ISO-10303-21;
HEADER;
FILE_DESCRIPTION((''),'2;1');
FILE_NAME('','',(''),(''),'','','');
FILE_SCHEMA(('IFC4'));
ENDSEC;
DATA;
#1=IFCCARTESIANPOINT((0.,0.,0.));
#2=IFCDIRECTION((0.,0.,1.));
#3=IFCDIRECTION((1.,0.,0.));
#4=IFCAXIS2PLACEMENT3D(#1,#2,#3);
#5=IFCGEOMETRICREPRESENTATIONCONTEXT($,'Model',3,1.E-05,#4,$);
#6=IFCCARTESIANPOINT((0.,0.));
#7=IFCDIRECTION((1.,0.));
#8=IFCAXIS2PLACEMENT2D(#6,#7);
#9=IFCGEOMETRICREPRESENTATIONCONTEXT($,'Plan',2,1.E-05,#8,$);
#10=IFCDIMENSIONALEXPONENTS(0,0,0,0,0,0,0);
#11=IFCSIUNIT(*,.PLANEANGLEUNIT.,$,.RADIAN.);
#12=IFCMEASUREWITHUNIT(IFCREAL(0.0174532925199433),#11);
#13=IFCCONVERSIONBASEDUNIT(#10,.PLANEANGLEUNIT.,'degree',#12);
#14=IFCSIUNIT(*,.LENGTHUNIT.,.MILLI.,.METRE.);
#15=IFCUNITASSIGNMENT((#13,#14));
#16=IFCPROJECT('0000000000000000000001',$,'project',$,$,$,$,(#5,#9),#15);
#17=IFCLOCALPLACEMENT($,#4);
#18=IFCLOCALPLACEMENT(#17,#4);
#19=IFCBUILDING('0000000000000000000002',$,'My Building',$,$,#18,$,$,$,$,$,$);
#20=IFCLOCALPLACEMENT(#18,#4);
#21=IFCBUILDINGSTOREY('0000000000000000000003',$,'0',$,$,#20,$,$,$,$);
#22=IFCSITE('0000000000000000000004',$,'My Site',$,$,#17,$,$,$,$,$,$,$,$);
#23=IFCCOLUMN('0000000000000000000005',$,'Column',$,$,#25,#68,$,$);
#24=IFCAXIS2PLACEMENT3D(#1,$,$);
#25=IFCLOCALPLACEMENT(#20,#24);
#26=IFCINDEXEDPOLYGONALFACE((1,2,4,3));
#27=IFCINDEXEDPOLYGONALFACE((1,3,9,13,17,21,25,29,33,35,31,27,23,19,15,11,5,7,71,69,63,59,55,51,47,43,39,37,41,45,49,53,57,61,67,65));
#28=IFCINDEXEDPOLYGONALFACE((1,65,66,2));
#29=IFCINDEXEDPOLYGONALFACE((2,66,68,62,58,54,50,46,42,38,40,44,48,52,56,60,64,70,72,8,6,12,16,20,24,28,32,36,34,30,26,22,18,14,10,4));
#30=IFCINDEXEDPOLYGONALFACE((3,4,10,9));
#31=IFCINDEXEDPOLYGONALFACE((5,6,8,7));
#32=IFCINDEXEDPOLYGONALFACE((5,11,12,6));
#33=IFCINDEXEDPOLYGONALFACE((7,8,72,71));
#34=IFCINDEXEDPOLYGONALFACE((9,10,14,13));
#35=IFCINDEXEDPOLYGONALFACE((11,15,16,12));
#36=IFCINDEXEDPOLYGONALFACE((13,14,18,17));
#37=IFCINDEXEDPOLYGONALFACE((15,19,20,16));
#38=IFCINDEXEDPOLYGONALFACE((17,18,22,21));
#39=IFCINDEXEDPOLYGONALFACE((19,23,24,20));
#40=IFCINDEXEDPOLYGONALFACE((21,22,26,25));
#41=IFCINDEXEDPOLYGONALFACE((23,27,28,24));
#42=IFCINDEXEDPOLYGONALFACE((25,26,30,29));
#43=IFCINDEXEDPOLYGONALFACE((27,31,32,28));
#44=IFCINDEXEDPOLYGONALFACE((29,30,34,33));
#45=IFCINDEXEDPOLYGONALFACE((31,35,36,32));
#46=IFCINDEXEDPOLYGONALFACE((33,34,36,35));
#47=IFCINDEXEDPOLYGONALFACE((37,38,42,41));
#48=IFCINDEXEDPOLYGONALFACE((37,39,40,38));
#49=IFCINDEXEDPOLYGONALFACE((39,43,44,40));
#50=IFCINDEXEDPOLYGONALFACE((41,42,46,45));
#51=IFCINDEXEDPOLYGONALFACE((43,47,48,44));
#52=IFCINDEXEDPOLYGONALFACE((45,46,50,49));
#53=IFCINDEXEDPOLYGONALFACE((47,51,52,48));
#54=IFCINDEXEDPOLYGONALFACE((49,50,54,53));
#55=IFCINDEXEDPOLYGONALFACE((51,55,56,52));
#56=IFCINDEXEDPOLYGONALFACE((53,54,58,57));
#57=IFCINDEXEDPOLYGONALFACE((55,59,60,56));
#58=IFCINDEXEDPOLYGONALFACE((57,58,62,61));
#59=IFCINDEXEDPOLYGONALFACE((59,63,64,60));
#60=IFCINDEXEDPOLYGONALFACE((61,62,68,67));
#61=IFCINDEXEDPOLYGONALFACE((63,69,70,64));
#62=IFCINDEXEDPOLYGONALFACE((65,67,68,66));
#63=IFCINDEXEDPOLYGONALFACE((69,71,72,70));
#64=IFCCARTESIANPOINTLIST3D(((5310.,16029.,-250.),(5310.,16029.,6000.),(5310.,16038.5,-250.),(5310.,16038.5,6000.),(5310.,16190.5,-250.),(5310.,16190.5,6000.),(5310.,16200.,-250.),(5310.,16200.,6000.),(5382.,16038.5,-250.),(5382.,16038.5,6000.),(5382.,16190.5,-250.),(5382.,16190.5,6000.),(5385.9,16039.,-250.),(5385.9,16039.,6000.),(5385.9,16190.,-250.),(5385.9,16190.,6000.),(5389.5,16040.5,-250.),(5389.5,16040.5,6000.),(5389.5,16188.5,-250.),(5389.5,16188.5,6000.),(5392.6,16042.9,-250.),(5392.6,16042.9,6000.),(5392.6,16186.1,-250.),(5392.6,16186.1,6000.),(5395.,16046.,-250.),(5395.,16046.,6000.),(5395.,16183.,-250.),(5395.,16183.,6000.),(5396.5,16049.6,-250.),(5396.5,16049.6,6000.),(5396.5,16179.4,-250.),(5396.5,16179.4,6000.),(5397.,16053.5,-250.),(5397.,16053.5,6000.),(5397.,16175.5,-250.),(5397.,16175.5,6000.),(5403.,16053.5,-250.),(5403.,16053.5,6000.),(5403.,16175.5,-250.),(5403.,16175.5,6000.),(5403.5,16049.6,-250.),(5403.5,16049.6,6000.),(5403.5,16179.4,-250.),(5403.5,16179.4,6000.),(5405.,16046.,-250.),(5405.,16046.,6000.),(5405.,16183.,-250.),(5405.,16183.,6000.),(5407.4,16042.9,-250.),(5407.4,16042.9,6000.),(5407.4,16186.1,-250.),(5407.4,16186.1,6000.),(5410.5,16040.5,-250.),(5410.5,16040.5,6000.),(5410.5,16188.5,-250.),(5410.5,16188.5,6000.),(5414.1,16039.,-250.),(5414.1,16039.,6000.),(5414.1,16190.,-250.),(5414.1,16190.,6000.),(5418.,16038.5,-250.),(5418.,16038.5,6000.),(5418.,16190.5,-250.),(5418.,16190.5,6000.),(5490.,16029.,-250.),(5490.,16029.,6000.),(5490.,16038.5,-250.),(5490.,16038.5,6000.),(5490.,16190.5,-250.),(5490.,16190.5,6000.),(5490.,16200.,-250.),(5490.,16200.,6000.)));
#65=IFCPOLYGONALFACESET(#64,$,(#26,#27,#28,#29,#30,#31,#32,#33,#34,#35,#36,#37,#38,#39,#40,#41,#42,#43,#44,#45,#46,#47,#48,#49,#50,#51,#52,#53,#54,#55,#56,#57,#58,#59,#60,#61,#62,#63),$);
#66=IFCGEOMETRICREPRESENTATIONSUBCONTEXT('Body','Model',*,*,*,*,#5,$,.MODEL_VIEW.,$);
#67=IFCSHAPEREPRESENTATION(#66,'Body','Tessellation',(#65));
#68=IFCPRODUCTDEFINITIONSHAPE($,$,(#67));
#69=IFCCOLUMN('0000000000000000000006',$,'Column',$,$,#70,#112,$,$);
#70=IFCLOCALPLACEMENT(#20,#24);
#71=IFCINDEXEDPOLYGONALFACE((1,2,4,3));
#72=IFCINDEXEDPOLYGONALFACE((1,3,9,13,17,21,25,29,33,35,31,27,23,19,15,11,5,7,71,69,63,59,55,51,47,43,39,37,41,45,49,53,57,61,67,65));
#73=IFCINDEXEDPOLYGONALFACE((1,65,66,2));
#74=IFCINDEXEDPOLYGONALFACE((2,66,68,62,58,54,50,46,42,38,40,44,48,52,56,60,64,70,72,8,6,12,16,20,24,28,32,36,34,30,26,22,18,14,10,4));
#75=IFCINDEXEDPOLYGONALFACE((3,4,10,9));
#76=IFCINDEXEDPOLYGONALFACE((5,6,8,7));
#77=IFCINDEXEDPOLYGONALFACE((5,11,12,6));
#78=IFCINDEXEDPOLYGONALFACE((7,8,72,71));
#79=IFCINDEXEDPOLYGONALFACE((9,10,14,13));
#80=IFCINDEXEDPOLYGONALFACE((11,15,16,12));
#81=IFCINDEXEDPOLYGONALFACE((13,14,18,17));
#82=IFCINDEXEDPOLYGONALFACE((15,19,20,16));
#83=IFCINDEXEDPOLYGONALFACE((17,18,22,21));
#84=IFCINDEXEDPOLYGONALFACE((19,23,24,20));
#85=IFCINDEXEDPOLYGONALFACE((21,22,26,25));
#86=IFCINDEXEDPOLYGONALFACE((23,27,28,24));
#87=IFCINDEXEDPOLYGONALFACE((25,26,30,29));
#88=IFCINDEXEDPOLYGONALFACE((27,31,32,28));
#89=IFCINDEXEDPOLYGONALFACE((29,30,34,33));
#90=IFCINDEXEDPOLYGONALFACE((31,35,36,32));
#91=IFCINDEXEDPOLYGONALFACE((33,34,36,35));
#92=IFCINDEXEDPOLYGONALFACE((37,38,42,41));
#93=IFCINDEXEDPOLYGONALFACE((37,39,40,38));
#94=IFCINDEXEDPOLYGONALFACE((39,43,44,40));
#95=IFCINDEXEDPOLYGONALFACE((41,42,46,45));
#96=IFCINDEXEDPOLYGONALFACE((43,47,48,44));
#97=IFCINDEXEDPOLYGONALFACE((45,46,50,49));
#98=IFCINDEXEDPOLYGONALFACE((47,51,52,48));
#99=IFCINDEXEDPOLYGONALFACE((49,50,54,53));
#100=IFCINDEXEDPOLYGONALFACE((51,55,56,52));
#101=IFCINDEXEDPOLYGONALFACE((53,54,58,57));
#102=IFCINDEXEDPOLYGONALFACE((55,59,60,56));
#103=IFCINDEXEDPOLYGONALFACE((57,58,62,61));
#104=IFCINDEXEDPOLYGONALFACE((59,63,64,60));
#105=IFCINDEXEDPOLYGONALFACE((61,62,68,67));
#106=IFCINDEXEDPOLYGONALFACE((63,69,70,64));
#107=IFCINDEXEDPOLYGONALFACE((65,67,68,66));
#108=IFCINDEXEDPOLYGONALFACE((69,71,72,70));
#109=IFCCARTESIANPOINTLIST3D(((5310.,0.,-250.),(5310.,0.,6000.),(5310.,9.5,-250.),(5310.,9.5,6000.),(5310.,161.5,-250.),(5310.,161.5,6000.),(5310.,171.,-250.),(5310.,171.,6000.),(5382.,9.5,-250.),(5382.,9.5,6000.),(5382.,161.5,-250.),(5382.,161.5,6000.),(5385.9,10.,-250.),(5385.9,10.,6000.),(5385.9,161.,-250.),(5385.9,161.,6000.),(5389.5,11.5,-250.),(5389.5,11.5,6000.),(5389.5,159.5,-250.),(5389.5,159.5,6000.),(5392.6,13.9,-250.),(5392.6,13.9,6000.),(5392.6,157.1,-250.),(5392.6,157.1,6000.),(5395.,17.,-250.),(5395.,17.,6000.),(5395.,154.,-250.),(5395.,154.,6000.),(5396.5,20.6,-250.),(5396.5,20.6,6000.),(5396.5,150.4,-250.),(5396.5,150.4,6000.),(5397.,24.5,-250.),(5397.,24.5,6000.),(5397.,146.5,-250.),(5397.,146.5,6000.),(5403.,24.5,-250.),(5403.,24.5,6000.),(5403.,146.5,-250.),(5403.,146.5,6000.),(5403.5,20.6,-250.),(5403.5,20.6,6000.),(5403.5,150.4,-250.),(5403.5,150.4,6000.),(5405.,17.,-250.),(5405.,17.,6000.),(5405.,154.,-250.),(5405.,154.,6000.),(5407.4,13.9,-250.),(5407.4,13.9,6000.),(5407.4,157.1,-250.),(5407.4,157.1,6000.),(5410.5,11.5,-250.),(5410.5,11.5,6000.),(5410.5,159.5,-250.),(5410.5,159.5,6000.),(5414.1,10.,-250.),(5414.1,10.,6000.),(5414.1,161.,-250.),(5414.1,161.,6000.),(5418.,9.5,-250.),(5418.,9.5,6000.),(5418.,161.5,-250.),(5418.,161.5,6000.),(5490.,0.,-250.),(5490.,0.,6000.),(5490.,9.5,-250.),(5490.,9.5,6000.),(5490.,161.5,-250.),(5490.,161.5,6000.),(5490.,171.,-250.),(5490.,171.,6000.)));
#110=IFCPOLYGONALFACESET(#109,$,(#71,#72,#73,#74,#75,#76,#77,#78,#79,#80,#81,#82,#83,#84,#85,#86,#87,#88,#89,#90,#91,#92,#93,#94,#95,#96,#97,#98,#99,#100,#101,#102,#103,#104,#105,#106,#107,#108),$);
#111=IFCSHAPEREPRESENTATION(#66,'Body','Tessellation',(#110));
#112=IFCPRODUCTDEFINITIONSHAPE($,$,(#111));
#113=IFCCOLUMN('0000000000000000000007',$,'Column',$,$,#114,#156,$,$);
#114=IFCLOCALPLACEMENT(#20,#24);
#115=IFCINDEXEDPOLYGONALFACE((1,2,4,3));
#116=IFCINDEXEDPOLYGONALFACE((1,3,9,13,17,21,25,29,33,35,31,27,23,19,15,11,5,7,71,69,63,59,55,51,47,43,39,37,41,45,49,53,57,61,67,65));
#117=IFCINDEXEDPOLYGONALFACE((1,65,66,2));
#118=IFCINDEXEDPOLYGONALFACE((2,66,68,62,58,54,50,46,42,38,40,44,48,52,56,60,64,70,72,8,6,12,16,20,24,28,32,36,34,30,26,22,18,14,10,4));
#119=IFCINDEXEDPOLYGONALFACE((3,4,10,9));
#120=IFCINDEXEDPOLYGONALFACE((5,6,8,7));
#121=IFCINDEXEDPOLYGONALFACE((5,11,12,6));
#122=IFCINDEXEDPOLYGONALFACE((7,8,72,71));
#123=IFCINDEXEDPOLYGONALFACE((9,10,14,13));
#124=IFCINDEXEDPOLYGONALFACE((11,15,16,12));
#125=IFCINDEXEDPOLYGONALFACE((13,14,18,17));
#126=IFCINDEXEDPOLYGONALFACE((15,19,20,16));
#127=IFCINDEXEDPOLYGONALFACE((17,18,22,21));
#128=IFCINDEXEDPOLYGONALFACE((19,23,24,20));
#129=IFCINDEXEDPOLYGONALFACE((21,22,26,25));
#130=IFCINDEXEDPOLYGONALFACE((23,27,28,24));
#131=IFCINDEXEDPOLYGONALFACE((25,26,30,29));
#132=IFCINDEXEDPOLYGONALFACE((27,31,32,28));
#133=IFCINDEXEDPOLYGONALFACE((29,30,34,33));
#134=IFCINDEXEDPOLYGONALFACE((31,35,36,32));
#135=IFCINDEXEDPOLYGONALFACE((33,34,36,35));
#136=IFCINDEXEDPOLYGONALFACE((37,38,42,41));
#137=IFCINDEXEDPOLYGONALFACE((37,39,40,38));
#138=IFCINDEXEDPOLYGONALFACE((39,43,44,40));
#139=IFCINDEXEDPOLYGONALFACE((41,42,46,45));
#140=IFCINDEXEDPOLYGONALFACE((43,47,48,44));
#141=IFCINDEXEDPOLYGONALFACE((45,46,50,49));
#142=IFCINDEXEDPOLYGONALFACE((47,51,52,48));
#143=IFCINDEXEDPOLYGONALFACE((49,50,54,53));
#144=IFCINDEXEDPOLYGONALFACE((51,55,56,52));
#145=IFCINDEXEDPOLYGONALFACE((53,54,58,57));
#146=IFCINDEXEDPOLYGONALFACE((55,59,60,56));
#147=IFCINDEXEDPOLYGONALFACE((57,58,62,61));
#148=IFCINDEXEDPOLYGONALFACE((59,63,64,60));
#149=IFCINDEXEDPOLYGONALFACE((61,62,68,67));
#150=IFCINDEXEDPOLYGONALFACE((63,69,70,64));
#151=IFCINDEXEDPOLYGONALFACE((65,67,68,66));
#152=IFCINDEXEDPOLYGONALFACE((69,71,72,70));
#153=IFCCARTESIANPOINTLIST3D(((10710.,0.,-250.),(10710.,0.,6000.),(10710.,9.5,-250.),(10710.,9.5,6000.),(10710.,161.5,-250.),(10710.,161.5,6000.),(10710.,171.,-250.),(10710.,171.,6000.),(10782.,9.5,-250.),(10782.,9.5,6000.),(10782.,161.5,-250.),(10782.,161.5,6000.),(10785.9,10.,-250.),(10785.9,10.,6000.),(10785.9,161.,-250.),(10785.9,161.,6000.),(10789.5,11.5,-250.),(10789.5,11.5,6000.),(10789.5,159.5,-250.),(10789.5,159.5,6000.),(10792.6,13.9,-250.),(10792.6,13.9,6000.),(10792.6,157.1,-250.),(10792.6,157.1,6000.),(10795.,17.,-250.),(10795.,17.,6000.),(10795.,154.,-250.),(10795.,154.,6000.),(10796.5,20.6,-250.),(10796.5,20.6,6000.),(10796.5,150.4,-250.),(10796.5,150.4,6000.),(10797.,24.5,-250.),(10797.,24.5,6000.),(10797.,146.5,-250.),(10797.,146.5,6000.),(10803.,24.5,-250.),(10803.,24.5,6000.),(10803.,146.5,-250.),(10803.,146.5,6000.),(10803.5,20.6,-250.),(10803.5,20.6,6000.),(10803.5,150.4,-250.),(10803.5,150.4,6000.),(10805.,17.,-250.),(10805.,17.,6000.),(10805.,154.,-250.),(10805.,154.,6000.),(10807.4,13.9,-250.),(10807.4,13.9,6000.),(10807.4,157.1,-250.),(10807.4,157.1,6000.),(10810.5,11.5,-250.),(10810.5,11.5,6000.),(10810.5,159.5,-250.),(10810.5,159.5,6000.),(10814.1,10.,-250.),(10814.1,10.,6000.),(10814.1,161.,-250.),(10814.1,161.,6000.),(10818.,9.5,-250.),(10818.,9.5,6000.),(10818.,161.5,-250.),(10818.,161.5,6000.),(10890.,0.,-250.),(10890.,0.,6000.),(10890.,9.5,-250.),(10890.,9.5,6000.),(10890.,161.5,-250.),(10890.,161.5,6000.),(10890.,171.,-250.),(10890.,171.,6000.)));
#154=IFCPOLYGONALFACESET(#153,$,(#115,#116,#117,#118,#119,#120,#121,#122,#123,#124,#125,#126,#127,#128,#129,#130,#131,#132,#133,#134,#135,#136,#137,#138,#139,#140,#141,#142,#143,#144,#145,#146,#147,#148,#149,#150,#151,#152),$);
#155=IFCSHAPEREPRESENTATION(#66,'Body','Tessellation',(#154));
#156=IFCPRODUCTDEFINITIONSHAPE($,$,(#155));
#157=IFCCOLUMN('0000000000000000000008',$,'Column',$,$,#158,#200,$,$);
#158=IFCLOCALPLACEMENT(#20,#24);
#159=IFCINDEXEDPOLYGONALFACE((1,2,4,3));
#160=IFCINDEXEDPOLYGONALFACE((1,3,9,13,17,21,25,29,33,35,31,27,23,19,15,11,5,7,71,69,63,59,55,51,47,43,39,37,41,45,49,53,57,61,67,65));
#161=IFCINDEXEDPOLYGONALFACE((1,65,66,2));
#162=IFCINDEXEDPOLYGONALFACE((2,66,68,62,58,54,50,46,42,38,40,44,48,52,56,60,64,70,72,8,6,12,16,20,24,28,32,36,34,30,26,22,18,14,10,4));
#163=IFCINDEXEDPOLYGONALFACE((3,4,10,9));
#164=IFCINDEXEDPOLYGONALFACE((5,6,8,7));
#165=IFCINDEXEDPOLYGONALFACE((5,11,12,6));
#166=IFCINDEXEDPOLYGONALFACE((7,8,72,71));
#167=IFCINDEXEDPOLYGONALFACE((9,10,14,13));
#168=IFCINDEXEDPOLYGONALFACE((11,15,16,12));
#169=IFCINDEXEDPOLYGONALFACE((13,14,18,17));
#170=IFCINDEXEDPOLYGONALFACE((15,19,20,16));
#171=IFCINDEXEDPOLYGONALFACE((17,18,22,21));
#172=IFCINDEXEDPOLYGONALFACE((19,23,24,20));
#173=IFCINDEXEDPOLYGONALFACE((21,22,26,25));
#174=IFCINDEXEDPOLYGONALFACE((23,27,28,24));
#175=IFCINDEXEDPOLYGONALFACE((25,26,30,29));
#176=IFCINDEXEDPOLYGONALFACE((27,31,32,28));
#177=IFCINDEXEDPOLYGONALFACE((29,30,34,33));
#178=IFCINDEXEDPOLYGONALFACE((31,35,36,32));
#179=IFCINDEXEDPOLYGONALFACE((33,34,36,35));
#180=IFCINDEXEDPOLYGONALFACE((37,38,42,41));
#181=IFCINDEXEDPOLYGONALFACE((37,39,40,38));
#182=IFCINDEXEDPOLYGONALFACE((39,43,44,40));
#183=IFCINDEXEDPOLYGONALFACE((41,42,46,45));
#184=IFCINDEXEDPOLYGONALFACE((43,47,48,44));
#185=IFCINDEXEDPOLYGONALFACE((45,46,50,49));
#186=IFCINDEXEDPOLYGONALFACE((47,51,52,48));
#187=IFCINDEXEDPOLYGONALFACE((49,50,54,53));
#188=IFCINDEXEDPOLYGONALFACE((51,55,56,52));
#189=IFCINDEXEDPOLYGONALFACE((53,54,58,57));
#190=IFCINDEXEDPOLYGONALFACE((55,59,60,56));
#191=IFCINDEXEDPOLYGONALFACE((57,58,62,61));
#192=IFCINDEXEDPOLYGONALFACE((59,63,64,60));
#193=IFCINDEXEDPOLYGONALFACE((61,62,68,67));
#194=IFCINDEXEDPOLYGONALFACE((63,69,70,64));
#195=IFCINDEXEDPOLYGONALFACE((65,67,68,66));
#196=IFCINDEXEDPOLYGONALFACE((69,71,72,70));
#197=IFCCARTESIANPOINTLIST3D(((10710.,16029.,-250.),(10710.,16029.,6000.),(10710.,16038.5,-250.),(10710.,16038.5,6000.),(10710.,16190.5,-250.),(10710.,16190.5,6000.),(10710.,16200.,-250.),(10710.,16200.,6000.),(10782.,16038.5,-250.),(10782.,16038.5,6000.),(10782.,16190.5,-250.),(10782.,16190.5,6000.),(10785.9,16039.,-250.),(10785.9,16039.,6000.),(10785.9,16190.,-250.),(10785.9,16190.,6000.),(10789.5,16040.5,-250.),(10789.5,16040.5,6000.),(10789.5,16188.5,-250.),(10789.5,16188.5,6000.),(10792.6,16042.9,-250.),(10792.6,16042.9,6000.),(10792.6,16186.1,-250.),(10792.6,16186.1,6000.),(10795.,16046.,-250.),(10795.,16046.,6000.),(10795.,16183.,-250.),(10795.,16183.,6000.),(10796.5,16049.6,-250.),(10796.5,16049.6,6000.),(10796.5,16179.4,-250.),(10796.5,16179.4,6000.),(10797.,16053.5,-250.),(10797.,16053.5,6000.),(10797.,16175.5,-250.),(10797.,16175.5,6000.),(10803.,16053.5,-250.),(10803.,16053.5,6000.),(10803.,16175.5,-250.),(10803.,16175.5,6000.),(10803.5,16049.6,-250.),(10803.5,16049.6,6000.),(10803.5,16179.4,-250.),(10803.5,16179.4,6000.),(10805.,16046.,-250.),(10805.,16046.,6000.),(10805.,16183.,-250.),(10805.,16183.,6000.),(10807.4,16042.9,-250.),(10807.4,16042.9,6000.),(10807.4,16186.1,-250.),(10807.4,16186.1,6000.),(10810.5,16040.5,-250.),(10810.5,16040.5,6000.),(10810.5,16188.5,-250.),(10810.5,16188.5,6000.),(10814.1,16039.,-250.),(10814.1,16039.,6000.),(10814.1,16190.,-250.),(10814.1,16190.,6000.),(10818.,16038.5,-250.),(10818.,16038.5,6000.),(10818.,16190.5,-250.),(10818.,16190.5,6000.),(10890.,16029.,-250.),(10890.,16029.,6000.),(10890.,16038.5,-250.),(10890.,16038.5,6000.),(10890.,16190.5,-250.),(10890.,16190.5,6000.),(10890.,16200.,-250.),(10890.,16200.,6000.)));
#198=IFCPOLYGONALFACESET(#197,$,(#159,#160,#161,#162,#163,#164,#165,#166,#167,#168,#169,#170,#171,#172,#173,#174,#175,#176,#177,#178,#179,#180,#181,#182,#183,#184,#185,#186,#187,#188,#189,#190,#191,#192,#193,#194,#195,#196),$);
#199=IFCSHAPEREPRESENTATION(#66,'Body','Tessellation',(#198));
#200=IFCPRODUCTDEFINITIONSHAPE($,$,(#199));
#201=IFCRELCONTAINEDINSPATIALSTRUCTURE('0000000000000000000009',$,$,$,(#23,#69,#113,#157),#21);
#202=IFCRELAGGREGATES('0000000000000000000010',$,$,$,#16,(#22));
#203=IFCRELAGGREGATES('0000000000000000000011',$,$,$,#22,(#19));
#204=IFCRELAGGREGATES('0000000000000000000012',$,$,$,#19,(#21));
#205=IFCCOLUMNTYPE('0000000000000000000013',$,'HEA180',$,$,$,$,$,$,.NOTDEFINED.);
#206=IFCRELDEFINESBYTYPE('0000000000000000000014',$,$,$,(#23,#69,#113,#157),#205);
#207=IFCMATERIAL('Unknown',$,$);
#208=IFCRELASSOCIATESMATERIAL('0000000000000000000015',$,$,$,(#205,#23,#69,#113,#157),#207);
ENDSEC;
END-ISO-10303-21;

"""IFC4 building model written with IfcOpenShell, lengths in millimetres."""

from ifc_helpers import new_model, entity, si_unit, converted_unit, frame, origin_with_axes, origin_2d_with_axis, place, context, subcontext, project, spatial, i_section, extrude, material, material_profile, profile_set, profile_usage, type_object, element, save


model = new_model("IFC4")

# Units and contexts
model_context = context("Model", 3, precision=1e-05, world=origin_with_axes())
plan_context = context("Plan", 2, precision=1e-05, world=origin_2d_with_axis())
body_context = subcontext(model_context, "Body", "Model", "MODEL_VIEW")
ifc_project = project(units=[converted_unit("PLANEANGLEUNIT", "degree", entity("IfcReal", 0.0174532925199433), si_unit("PLANEANGLEUNIT", "RADIAN"), dimensions=[0, 0, 0, 0, 0, 0, 0]), si_unit("LENGTHUNIT", "METRE", prefix="MILLI")], contexts=[model_context, plan_context])

# Site, building, storey
site_placement = place(None, origin_with_axes())
site = spatial("IfcSite", under=ifc_project, at=site_placement, Name="My Site")
building_placement = place(site_placement, origin_with_axes())
building = spatial("IfcBuilding", under=site, at=building_placement, Name="My Building")
storey_placement = place(building_placement, origin_with_axes())
storey = spatial("IfcBuildingStorey", under=building, at=storey_placement, Name="0")

# Columns
ifc_material = material(Name="Unknown")
ifc_material_profile_1 = material_profile(ifc_material, i_section(OverallWidth=180.0, OverallDepth=171.0, WebThickness=6.0, FlangeThickness=9.5, FilletRadius=15.0))
ifc_profile_set_1 = profile_set([ifc_material_profile_1])
column_type = type_object("IfcColumnType", Name="HEA180", PredefinedType="NOTDEFINED", material=ifc_profile_set_1)
ifc_profile_usage_1 = profile_usage(ifc_profile_set_1, cardinal=8)
column_1_placement = place(storey_placement, frame((5400.0, 16200.0, -250.0), z_axis=(0.0, 0.0, 1.0), x_axis=(1.0, 0.0, 0.0)))
element("IfcColumn", 1, at=column_1_placement, inside=storey, type_object=column_type, material=ifc_profile_usage_1, Name="Column", context=body_context, shape_type="SweptSolid", body=[
    extrude(i_section(OverallWidth=180.0, OverallDepth=171.0, WebThickness=6.0, FlangeThickness=9.5, FilletRadius=15.0), frame((0.0, -85.5, 0.0), z_axis=(0.0, 0.0, 1.0), x_axis=(1.0, 0.0, 0.0)), (0.0, 0.0, 1.0), 6250.0),
])
ifc_profile_usage_2 = profile_usage(ifc_profile_set_1, cardinal=2)
column_2_placement = place(storey_placement, frame((5400.0, 0.0, -250.0), z_axis=(0.0, 0.0, 1.0), x_axis=(1.0, 0.0, 0.0)))
element("IfcColumn", 2, at=column_2_placement, inside=storey, type_object=column_type, material=ifc_profile_usage_2, Name="Column", context=body_context, shape_type="SweptSolid", body=[
    extrude(i_section(OverallWidth=180.0, OverallDepth=171.0, WebThickness=6.0, FlangeThickness=9.5, FilletRadius=15.0), frame((0.0, 85.5, 0.0), z_axis=(0.0, 0.0, 1.0), x_axis=(1.0, 0.0, 0.0)), (0.0, 0.0, 1.0), 6250.0),
])
ifc_profile_usage_3 = profile_usage(ifc_profile_set_1, cardinal=2)
column_3_placement = place(storey_placement, frame((10800.0, 0.0, -250.0), z_axis=(0.0, 0.0, 1.0), x_axis=(1.0, 0.0, 0.0)))
element("IfcColumn", 3, at=column_3_placement, inside=storey, type_object=column_type, material=ifc_profile_usage_3, Name="Column", context=body_context, shape_type="SweptSolid", body=[
    extrude(i_section(OverallWidth=180.0, OverallDepth=171.0, WebThickness=6.0, FlangeThickness=9.5, FilletRadius=15.0), frame((0.0, 85.5, 0.0), z_axis=(0.0, 0.0, 1.0), x_axis=(1.0, 0.0, 0.0)), (0.0, 0.0, 1.0), 6250.0),
])
ifc_profile_usage_4 = profile_usage(ifc_profile_set_1, cardinal=8)
column_4_placement = place(storey_placement, frame((10800.0, 16200.0, -250.0), z_axis=(0.0, 0.0, 1.0), x_axis=(1.0, 0.0, 0.0)))
element("IfcColumn", 4, at=column_4_placement, inside=storey, type_object=column_type, material=ifc_profile_usage_4, Name="Column", context=body_context, shape_type="SweptSolid", body=[
    extrude(i_section(OverallWidth=180.0, OverallDepth=171.0, WebThickness=6.0, FlangeThickness=9.5, FilletRadius=15.0), frame((0.0, -85.5, 0.0), z_axis=(0.0, 0.0, 1.0), x_axis=(1.0, 0.0, 0.0)), (0.0, 0.0, 1.0), 6250.0),
])

save(model, "model.ifc")
